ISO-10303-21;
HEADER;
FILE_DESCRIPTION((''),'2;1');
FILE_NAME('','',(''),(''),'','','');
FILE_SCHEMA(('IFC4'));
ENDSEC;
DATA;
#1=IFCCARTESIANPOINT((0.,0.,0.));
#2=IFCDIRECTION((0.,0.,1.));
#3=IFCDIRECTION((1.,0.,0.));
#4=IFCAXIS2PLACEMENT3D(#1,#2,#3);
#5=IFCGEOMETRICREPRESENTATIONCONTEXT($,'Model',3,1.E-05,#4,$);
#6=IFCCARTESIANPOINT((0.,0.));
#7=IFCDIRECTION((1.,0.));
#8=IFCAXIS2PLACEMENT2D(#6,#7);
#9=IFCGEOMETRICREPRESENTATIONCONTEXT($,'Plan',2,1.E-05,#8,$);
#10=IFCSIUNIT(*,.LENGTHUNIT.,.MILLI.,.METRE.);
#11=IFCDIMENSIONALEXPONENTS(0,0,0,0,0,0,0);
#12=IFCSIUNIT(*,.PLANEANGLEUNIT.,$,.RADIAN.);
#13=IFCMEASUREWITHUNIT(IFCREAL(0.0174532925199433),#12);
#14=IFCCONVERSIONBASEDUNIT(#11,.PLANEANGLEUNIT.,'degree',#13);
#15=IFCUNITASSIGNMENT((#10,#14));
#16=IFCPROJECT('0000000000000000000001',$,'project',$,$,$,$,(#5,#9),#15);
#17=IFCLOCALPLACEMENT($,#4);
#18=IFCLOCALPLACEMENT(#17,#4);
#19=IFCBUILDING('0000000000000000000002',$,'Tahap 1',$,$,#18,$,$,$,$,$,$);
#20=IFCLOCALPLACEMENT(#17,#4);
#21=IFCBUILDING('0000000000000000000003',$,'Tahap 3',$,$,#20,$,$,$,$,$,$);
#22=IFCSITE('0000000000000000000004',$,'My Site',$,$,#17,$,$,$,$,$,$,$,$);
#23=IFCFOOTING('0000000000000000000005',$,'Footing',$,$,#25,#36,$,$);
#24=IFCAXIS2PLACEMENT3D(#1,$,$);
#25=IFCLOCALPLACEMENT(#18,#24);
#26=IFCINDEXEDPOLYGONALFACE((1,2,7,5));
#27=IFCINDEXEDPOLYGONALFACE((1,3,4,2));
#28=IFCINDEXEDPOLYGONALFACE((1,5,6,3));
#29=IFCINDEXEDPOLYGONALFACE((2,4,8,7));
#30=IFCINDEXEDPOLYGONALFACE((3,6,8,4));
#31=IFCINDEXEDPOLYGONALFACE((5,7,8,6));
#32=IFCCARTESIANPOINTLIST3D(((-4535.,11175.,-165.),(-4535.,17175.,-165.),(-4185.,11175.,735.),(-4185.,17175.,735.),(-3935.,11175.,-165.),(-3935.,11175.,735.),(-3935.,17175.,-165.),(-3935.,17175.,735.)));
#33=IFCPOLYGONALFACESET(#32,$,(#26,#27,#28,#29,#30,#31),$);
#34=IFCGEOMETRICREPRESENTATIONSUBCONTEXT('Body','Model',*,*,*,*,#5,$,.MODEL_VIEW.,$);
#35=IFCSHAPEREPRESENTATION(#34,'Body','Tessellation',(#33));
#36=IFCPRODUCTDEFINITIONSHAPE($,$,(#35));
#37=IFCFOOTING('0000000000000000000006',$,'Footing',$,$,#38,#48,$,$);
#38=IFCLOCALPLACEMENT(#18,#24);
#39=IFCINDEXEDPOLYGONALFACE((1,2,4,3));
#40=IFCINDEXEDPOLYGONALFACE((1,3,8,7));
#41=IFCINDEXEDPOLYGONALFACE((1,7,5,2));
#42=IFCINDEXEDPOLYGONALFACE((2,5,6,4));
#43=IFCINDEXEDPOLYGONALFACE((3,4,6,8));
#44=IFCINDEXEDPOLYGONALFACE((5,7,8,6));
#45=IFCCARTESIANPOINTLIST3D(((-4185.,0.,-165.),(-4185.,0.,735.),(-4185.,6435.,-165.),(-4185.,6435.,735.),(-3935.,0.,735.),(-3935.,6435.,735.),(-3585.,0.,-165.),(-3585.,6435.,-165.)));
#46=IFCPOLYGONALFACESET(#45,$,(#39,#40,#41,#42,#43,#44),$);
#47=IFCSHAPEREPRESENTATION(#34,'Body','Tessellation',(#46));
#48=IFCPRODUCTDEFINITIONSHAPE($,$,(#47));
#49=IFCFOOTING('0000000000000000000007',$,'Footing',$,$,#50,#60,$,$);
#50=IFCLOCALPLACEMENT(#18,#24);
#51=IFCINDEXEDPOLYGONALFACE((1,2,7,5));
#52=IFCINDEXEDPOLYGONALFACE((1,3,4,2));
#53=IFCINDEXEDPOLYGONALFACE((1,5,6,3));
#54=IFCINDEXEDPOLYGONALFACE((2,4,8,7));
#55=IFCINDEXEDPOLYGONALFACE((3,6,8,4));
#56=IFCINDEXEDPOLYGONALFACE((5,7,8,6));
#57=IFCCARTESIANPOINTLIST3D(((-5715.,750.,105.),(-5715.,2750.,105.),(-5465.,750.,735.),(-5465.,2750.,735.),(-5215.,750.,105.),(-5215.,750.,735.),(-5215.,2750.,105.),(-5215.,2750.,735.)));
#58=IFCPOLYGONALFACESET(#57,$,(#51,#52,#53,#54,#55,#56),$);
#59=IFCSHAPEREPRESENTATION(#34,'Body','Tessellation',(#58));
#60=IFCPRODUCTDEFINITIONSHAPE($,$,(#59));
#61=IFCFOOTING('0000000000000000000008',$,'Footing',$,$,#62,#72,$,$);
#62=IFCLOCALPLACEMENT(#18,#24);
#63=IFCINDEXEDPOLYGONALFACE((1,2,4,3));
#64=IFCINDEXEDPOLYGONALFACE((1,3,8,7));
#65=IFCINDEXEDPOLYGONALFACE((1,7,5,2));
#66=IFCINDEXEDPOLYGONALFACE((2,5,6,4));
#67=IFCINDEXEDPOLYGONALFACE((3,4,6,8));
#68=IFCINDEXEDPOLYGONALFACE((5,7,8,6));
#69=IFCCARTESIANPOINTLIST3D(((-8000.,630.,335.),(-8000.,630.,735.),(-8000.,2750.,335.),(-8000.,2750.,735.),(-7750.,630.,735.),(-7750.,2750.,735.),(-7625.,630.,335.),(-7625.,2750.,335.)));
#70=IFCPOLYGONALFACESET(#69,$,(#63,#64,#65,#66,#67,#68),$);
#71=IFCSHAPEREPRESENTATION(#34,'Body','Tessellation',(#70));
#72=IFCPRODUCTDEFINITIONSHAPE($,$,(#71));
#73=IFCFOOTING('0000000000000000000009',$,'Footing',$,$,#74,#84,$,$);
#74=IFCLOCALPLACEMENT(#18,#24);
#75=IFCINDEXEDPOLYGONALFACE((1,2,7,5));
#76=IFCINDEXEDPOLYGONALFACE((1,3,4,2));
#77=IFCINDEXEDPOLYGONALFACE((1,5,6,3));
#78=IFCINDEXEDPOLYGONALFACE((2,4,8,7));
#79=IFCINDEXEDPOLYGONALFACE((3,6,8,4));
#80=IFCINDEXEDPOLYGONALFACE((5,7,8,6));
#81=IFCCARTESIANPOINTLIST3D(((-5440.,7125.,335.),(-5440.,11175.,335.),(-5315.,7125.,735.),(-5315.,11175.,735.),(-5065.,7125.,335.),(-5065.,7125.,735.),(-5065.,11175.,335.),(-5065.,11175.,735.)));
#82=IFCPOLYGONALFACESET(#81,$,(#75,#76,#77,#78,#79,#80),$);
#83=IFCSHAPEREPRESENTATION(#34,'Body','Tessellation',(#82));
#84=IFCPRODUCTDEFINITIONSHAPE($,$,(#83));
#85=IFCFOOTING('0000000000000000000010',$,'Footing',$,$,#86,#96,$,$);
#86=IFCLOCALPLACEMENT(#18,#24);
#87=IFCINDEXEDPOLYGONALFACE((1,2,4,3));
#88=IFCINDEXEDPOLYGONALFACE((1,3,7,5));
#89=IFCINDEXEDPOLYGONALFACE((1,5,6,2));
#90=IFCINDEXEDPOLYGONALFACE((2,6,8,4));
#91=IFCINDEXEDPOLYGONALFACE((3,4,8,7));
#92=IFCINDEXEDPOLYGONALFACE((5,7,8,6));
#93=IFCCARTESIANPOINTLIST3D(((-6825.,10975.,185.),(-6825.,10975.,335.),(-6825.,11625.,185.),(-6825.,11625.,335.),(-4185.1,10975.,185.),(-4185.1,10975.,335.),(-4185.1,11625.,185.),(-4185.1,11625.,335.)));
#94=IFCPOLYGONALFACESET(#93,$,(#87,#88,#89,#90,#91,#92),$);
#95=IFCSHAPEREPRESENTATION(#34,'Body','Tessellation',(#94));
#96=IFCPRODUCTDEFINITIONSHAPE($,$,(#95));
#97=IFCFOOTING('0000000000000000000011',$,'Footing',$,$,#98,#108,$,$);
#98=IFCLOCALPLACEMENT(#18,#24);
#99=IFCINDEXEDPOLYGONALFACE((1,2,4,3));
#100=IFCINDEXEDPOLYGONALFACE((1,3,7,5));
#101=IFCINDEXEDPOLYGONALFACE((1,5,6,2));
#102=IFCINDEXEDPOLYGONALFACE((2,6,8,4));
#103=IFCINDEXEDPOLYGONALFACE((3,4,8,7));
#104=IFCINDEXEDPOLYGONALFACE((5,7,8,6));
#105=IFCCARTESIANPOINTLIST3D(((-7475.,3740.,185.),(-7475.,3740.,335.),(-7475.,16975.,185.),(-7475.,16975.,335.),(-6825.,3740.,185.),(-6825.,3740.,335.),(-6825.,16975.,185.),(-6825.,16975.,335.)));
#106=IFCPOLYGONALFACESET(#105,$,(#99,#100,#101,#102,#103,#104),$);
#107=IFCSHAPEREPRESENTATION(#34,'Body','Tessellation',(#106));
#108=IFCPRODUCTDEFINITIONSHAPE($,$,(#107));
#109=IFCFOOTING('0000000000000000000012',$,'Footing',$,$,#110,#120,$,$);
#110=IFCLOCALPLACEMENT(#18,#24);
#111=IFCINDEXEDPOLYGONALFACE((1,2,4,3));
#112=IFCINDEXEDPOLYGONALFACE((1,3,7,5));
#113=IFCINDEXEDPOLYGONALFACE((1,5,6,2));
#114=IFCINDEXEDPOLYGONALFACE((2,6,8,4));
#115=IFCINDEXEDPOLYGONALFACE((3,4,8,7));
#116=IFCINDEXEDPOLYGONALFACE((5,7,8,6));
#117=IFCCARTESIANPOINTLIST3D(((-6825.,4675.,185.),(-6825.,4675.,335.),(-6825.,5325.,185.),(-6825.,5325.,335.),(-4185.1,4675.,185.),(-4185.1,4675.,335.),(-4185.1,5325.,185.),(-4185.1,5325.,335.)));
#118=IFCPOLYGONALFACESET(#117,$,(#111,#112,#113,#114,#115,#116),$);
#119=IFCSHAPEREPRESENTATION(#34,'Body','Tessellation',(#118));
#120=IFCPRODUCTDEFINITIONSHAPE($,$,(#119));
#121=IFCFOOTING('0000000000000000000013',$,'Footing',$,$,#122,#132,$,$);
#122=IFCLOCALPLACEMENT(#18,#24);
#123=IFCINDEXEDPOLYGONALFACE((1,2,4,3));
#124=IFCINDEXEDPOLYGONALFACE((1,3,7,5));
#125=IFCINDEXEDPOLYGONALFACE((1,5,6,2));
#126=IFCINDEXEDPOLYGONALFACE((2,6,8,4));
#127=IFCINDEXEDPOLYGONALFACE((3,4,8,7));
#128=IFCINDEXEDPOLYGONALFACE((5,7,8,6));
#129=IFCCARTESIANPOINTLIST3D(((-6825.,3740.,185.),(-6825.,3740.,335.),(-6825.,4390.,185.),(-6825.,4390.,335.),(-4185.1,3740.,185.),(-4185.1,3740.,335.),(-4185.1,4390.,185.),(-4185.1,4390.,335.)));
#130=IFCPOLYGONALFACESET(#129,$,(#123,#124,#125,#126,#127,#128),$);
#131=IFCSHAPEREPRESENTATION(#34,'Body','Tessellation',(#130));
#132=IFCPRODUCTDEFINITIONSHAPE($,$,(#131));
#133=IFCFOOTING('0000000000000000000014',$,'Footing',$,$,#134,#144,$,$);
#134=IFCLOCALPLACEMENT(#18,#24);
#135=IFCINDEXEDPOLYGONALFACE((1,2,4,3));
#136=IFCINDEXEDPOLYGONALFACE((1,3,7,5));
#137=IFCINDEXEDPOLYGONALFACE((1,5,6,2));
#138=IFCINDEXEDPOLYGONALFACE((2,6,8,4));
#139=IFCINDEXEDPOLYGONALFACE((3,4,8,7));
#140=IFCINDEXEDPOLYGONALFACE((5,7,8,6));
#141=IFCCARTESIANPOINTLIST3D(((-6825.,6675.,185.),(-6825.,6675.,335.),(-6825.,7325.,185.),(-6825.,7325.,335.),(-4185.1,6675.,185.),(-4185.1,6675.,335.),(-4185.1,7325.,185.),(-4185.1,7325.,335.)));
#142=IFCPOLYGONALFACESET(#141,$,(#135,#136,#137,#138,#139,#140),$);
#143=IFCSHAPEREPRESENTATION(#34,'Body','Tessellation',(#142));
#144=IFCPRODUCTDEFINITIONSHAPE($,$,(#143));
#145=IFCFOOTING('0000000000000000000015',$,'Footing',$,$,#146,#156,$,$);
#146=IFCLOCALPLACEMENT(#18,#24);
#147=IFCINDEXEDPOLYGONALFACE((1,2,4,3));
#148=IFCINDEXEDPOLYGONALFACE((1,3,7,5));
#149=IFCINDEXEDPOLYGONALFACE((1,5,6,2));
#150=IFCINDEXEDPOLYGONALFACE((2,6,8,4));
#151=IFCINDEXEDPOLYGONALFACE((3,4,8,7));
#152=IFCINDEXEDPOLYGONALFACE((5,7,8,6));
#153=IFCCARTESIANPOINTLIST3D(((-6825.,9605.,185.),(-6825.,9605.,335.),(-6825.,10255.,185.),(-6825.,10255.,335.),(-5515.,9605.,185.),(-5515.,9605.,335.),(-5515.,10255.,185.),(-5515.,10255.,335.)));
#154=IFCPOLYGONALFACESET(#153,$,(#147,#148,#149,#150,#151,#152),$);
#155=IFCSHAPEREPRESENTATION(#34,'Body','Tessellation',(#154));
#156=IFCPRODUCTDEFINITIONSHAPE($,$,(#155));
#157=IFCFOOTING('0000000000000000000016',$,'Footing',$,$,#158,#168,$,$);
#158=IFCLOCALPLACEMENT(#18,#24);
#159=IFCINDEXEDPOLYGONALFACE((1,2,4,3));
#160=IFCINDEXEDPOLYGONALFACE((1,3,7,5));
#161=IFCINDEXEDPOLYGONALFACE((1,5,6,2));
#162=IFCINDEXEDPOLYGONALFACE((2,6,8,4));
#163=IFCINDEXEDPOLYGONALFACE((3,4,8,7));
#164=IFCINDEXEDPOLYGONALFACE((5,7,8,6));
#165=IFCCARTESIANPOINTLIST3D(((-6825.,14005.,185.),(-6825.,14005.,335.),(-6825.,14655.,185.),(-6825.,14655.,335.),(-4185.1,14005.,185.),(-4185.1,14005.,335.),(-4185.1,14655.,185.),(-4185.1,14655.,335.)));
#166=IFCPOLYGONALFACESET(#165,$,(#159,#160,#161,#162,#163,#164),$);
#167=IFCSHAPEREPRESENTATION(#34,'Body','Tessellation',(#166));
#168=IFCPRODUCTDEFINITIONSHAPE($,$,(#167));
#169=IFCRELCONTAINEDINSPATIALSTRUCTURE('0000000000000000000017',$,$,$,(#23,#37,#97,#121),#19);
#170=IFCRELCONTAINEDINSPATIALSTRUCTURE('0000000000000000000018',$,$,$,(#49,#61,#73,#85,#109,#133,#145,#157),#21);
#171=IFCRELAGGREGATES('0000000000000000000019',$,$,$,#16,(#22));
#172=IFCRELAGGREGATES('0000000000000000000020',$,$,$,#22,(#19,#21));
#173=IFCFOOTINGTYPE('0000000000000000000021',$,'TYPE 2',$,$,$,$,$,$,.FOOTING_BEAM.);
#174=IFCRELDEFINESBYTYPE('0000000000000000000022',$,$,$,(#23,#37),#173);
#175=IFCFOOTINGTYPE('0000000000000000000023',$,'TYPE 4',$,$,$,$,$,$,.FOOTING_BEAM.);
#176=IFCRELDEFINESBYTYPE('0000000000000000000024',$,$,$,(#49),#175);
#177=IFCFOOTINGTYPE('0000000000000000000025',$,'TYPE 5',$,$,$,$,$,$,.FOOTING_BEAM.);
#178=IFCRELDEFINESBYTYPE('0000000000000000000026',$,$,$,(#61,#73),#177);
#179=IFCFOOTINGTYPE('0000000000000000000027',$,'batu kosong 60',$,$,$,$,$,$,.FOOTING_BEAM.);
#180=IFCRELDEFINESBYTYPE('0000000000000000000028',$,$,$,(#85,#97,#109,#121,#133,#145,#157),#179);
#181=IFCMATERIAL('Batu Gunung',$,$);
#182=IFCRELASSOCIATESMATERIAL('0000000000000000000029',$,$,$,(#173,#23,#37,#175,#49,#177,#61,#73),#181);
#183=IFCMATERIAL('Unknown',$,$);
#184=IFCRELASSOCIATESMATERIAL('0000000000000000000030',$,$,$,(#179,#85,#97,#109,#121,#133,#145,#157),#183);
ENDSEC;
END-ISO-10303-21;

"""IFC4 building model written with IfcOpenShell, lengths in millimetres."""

from ifc_helpers import new_model, entity, si_unit, converted_unit, frame, origin_with_axes, origin_2d_with_axis, place, context, subcontext, project, spatial, indexed_curve, rectangle, outline, extrude, material, material_profile, profile_set, profile_usage, type_object, element, save


model = new_model("IFC4")

# Units and contexts
model_context = context("Model", 3, precision=1e-05, world=origin_with_axes())
plan_context = context("Plan", 2, precision=1e-05, world=origin_2d_with_axis())
body_context = subcontext(model_context, "Body", "Model", "MODEL_VIEW")
ifc_project = project(units=[si_unit("LENGTHUNIT", "METRE", prefix="MILLI"), converted_unit("PLANEANGLEUNIT", "degree", entity("IfcReal", 0.0174532925199433), si_unit("PLANEANGLEUNIT", "RADIAN"), dimensions=[0, 0, 0, 0, 0, 0, 0])], contexts=[model_context, plan_context])

# Site, building
site_placement = place(None, origin_with_axes())
site = spatial("IfcSite", under=ifc_project, at=site_placement, Name="My Site")
building_1_placement = place(site_placement, origin_with_axes())
building_1 = spatial("IfcBuilding", under=site, at=building_1_placement, Name="Tahap 1")

# Footings
ifc_material_1 = material(Name="Batu Gunung")
ifc_material_profile_1 = material_profile(ifc_material_1, outline(indexed_curve([(-125.0, -900.0), (475.0, -900.0), (125.0, 0.0), (-125.0, 0.0), (-125.0, -900.0)])))
ifc_profile_set_1 = profile_set([ifc_material_profile_1])
ifc_profile_usage_1 = profile_usage(ifc_profile_set_1, cardinal=5)
footing_type_1 = type_object("IfcFootingType", Name="TYPE 2", PredefinedType="FOOTING_BEAM", material=ifc_profile_set_1)
footing_1_placement = place(building_1_placement, frame((-4060.0, 11175.0, 735.0), z_axis=(0.0, 1.0, 0.0), x_axis=(-1.0, 0.0, 0.0)))
element("IfcFooting", 1, at=footing_1_placement, inside=building_1, type_object=footing_type_1, material=ifc_profile_usage_1, Name="Footing", context=body_context, shape_type="SweptSolid", body=[
    extrude(outline(indexed_curve([(-125.0, -900.0), (475.0, -900.0), (125.0, 0.0), (-125.0, 0.0), (-125.0, -900.0)])), origin_with_axes(), (0.0, 0.0, 1.0), 6000.0),
])
ifc_profile_usage_2 = profile_usage(ifc_profile_set_1, cardinal=5)
footing_2_placement = place(building_1_placement, frame((-4060.0, 6435.0, 735.0), z_axis=(0.0, -1.0, 0.0), x_axis=(1.0, 0.0, 0.0)))
element("IfcFooting", 2, at=footing_2_placement, inside=building_1, type_object=footing_type_1, material=ifc_profile_usage_2, Name="Footing", context=body_context, shape_type="SweptSolid", body=[
    extrude(outline(indexed_curve([(-125.0, -900.0), (475.0, -900.0), (125.0, 0.0), (-125.0, 0.0), (-125.0, -900.0)])), origin_with_axes(), (0.0, 0.0, 1.0), 6435.0),
])

# Shared definitions
building_2_placement = place(site_placement, origin_with_axes())
building_2 = spatial("IfcBuilding", under=site, at=building_2_placement, Name="Tahap 3")

# Footings
ifc_material_profile_2 = material_profile(ifc_material_1, outline(indexed_curve([(-125.0, 0.0), (125.0, 0.0), (375.0, -630.0), (-125.0, -630.0), (-125.0, 0.0)])))
ifc_profile_set_2 = profile_set([ifc_material_profile_2])
ifc_profile_usage_3 = profile_usage(ifc_profile_set_2)
footing_type_2 = type_object("IfcFootingType", Name="TYPE 4", PredefinedType="FOOTING_BEAM", material=ifc_profile_set_2)
footing_3_placement = place(building_2_placement, frame((-5340.0, 750.0, 735.0), z_axis=(0.000001, 1.0, 0.0), x_axis=(-1.0, 0.000001, 0.0)))
element("IfcFooting", 3, at=footing_3_placement, inside=building_2, type_object=footing_type_2, material=ifc_profile_usage_3, Name="Footing", context=body_context, shape_type="SweptSolid", body=[
    extrude(outline(indexed_curve([(-125.0, 0.0), (125.0, 0.0), (375.0, -630.0), (-125.0, -630.0), (-125.0, 0.0)])), origin_with_axes(), (0.0, 0.0, 1.0), 2000.0),
])
ifc_material_profile_3 = material_profile(ifc_material_1, outline(indexed_curve([(-125.0, -400.0), (250.0, -400.0), (125.0, 0.0), (-125.0, 0.0), (-125.0, -400.0)])))
ifc_profile_set_3 = profile_set([ifc_material_profile_3])
ifc_profile_usage_4 = profile_usage(ifc_profile_set_3, cardinal=5)
footing_type_3 = type_object("IfcFootingType", Name="TYPE 5", PredefinedType="FOOTING_BEAM", material=ifc_profile_set_3)
footing_4_placement = place(building_2_placement, frame((-7875.0, 2750.0, 735.0), z_axis=(0.0, -1.0, 0.0), x_axis=(1.0, 0.0, 0.0)))
element("IfcFooting", 4, at=footing_4_placement, inside=building_2, type_object=footing_type_3, material=ifc_profile_usage_4, Name="Footing", context=body_context, shape_type="SweptSolid", body=[
    extrude(outline(indexed_curve([(-125.0, -400.0), (250.0, -400.0), (125.0, 0.0), (-125.0, 0.0), (-125.0, -400.0)])), origin_with_axes(), (0.0, 0.0, 1.0), 2120.0),
])
ifc_profile_usage_5 = profile_usage(ifc_profile_set_3, cardinal=2)
footing_5_placement = place(building_2_placement, frame((-5190.0, 7125.0, 535.0), z_axis=(0.0, 1.0, 0.0), x_axis=(-1.0, 0.0, 0.0)))
element("IfcFooting", 5, at=footing_5_placement, inside=building_2, type_object=footing_type_3, material=ifc_profile_usage_5, Name="Footing", context=body_context, shape_type="SweptSolid", body=[
    extrude(outline(indexed_curve([(-125.0, -400.0), (250.0, -400.0), (125.0, 0.0), (-125.0, 0.0), (-125.0, -400.0)])), frame((0.0, 200.0, 0.0), z_axis=(0.0, 0.0, 1.0), x_axis=(1.0, 0.0, 0.0)), (0.0, 0.0, 1.0), 4050.0),
])
ifc_material_2 = material(Name="Unknown")
ifc_material_profile_4 = material_profile(ifc_material_2, rectangle(XDim=650.0, YDim=150.0, kind="CURVE"))
ifc_profile_set_4 = profile_set([ifc_material_profile_4])
ifc_profile_usage_6 = profile_usage(ifc_profile_set_4, cardinal=8)
footing_type_4 = type_object("IfcFootingType", Name="batu kosong 60", PredefinedType="FOOTING_BEAM", material=ifc_profile_set_4)
footing_6_placement = place(building_2_placement, frame((-6825.0, 11300.0, 335.0), z_axis=(1.0, 0.0, 0.0), x_axis=(0.0, 1.0, 0.0)))
element("IfcFooting", 6, at=footing_6_placement, inside=building_2, type_object=footing_type_4, material=ifc_profile_usage_6, Name="Footing", context=body_context, shape_type="SweptSolid", body=[
    extrude(rectangle(XDim=650.0, YDim=150.0, kind="CURVE"), frame((0.0, -75.0, 0.0), z_axis=(0.0, 0.0, 1.0), x_axis=(1.0, 0.0, 0.0)), (0.0, 0.0, 1.0), 2639.9),
])
ifc_profile_usage_7 = profile_usage(ifc_profile_set_4, cardinal=8)
footing_7_placement = place(building_1_placement, frame((-7150.0, 3740.0, 335.0), z_axis=(0.0, 1.0, 0.0), x_axis=(-1.0, 0.0, 0.0)))
element("IfcFooting", 7, at=footing_7_placement, inside=building_1, type_object=footing_type_4, material=ifc_profile_usage_7, Name="Footing", context=body_context, shape_type="SweptSolid", body=[
    extrude(rectangle(XDim=650.0, YDim=150.0, kind="CURVE"), frame((0.0, -75.0, 0.0), z_axis=(0.0, 0.0, 1.0), x_axis=(1.0, 0.0, 0.0)), (0.0, 0.0, 1.0), 13235.0),
])
ifc_profile_usage_8 = profile_usage(ifc_profile_set_4, cardinal=8)
footing_8_placement = place(building_2_placement, frame((-6825.0, 5000.0, 335.0), z_axis=(1.0, 0.0, 0.0), x_axis=(0.0, 1.0, 0.0)))
element("IfcFooting", 8, at=footing_8_placement, inside=building_2, type_object=footing_type_4, material=ifc_profile_usage_8, Name="Footing", context=body_context, shape_type="SweptSolid", body=[
    extrude(rectangle(XDim=650.0, YDim=150.0, kind="CURVE"), frame((0.0, -75.0, 0.0), z_axis=(0.0, 0.0, 1.0), x_axis=(1.0, 0.0, 0.0)), (0.0, 0.0, 1.0), 2639.9),
])
ifc_profile_usage_9 = profile_usage(ifc_profile_set_4, cardinal=8)
footing_9_placement = place(building_1_placement, frame((-6825.0, 4065.0, 335.0), z_axis=(1.0, 0.0, 0.0), x_axis=(0.0, 1.0, 0.0)))
element("IfcFooting", 9, at=footing_9_placement, inside=building_1, type_object=footing_type_4, material=ifc_profile_usage_9, Name="Footing", context=body_context, shape_type="SweptSolid", body=[
    extrude(rectangle(XDim=650.0, YDim=150.0, kind="CURVE"), frame((0.0, -75.0, 0.0), z_axis=(0.0, 0.0, 1.0), x_axis=(1.0, 0.0, 0.0)), (0.0, 0.0, 1.0), 2639.9),
])
ifc_profile_usage_10 = profile_usage(ifc_profile_set_4, cardinal=8)
footing_10_placement = place(building_2_placement, frame((-6825.0, 7000.0, 335.0), z_axis=(1.0, 0.0, 0.0), x_axis=(0.0, 1.0, 0.0)))
element("IfcFooting", 10, at=footing_10_placement, inside=building_2, type_object=footing_type_4, material=ifc_profile_usage_10, Name="Footing", context=body_context, shape_type="SweptSolid", body=[
    extrude(rectangle(XDim=650.0, YDim=150.0, kind="CURVE"), frame((0.0, -75.0, 0.0), z_axis=(0.0, 0.0, 1.0), x_axis=(1.0, 0.0, 0.0)), (0.0, 0.0, 1.0), 2639.9),
])
ifc_profile_usage_11 = profile_usage(ifc_profile_set_4, cardinal=8)
footing_11_placement = place(building_2_placement, frame((-6825.0, 9930.0, 335.0), z_axis=(1.0, 0.0, 0.0), x_axis=(0.0, 1.0, 0.0)))
element("IfcFooting", 11, at=footing_11_placement, inside=building_2, type_object=footing_type_4, material=ifc_profile_usage_11, Name="Footing", context=body_context, shape_type="SweptSolid", body=[
    extrude(rectangle(XDim=650.0, YDim=150.0, kind="CURVE"), frame((0.0, -75.0, 0.0), z_axis=(0.0, 0.0, 1.0), x_axis=(1.0, 0.0, 0.0)), (0.0, 0.0, 1.0), 1310.0),
])
ifc_profile_usage_12 = profile_usage(ifc_profile_set_4, cardinal=8)
footing_12_placement = place(building_2_placement, frame((-6825.0, 14330.0, 335.0), z_axis=(1.0, 0.0, 0.0), x_axis=(0.0, 1.0, 0.0)))
element("IfcFooting", 12, at=footing_12_placement, inside=building_2, type_object=footing_type_4, material=ifc_profile_usage_12, Name="Footing", context=body_context, shape_type="SweptSolid", body=[
    extrude(rectangle(XDim=650.0, YDim=150.0, kind="CURVE"), frame((0.0, -75.0, 0.0), z_axis=(0.0, 0.0, 1.0), x_axis=(1.0, 0.0, 0.0)), (0.0, 0.0, 1.0), 2639.9),
])

save(model, "model.ifc")
